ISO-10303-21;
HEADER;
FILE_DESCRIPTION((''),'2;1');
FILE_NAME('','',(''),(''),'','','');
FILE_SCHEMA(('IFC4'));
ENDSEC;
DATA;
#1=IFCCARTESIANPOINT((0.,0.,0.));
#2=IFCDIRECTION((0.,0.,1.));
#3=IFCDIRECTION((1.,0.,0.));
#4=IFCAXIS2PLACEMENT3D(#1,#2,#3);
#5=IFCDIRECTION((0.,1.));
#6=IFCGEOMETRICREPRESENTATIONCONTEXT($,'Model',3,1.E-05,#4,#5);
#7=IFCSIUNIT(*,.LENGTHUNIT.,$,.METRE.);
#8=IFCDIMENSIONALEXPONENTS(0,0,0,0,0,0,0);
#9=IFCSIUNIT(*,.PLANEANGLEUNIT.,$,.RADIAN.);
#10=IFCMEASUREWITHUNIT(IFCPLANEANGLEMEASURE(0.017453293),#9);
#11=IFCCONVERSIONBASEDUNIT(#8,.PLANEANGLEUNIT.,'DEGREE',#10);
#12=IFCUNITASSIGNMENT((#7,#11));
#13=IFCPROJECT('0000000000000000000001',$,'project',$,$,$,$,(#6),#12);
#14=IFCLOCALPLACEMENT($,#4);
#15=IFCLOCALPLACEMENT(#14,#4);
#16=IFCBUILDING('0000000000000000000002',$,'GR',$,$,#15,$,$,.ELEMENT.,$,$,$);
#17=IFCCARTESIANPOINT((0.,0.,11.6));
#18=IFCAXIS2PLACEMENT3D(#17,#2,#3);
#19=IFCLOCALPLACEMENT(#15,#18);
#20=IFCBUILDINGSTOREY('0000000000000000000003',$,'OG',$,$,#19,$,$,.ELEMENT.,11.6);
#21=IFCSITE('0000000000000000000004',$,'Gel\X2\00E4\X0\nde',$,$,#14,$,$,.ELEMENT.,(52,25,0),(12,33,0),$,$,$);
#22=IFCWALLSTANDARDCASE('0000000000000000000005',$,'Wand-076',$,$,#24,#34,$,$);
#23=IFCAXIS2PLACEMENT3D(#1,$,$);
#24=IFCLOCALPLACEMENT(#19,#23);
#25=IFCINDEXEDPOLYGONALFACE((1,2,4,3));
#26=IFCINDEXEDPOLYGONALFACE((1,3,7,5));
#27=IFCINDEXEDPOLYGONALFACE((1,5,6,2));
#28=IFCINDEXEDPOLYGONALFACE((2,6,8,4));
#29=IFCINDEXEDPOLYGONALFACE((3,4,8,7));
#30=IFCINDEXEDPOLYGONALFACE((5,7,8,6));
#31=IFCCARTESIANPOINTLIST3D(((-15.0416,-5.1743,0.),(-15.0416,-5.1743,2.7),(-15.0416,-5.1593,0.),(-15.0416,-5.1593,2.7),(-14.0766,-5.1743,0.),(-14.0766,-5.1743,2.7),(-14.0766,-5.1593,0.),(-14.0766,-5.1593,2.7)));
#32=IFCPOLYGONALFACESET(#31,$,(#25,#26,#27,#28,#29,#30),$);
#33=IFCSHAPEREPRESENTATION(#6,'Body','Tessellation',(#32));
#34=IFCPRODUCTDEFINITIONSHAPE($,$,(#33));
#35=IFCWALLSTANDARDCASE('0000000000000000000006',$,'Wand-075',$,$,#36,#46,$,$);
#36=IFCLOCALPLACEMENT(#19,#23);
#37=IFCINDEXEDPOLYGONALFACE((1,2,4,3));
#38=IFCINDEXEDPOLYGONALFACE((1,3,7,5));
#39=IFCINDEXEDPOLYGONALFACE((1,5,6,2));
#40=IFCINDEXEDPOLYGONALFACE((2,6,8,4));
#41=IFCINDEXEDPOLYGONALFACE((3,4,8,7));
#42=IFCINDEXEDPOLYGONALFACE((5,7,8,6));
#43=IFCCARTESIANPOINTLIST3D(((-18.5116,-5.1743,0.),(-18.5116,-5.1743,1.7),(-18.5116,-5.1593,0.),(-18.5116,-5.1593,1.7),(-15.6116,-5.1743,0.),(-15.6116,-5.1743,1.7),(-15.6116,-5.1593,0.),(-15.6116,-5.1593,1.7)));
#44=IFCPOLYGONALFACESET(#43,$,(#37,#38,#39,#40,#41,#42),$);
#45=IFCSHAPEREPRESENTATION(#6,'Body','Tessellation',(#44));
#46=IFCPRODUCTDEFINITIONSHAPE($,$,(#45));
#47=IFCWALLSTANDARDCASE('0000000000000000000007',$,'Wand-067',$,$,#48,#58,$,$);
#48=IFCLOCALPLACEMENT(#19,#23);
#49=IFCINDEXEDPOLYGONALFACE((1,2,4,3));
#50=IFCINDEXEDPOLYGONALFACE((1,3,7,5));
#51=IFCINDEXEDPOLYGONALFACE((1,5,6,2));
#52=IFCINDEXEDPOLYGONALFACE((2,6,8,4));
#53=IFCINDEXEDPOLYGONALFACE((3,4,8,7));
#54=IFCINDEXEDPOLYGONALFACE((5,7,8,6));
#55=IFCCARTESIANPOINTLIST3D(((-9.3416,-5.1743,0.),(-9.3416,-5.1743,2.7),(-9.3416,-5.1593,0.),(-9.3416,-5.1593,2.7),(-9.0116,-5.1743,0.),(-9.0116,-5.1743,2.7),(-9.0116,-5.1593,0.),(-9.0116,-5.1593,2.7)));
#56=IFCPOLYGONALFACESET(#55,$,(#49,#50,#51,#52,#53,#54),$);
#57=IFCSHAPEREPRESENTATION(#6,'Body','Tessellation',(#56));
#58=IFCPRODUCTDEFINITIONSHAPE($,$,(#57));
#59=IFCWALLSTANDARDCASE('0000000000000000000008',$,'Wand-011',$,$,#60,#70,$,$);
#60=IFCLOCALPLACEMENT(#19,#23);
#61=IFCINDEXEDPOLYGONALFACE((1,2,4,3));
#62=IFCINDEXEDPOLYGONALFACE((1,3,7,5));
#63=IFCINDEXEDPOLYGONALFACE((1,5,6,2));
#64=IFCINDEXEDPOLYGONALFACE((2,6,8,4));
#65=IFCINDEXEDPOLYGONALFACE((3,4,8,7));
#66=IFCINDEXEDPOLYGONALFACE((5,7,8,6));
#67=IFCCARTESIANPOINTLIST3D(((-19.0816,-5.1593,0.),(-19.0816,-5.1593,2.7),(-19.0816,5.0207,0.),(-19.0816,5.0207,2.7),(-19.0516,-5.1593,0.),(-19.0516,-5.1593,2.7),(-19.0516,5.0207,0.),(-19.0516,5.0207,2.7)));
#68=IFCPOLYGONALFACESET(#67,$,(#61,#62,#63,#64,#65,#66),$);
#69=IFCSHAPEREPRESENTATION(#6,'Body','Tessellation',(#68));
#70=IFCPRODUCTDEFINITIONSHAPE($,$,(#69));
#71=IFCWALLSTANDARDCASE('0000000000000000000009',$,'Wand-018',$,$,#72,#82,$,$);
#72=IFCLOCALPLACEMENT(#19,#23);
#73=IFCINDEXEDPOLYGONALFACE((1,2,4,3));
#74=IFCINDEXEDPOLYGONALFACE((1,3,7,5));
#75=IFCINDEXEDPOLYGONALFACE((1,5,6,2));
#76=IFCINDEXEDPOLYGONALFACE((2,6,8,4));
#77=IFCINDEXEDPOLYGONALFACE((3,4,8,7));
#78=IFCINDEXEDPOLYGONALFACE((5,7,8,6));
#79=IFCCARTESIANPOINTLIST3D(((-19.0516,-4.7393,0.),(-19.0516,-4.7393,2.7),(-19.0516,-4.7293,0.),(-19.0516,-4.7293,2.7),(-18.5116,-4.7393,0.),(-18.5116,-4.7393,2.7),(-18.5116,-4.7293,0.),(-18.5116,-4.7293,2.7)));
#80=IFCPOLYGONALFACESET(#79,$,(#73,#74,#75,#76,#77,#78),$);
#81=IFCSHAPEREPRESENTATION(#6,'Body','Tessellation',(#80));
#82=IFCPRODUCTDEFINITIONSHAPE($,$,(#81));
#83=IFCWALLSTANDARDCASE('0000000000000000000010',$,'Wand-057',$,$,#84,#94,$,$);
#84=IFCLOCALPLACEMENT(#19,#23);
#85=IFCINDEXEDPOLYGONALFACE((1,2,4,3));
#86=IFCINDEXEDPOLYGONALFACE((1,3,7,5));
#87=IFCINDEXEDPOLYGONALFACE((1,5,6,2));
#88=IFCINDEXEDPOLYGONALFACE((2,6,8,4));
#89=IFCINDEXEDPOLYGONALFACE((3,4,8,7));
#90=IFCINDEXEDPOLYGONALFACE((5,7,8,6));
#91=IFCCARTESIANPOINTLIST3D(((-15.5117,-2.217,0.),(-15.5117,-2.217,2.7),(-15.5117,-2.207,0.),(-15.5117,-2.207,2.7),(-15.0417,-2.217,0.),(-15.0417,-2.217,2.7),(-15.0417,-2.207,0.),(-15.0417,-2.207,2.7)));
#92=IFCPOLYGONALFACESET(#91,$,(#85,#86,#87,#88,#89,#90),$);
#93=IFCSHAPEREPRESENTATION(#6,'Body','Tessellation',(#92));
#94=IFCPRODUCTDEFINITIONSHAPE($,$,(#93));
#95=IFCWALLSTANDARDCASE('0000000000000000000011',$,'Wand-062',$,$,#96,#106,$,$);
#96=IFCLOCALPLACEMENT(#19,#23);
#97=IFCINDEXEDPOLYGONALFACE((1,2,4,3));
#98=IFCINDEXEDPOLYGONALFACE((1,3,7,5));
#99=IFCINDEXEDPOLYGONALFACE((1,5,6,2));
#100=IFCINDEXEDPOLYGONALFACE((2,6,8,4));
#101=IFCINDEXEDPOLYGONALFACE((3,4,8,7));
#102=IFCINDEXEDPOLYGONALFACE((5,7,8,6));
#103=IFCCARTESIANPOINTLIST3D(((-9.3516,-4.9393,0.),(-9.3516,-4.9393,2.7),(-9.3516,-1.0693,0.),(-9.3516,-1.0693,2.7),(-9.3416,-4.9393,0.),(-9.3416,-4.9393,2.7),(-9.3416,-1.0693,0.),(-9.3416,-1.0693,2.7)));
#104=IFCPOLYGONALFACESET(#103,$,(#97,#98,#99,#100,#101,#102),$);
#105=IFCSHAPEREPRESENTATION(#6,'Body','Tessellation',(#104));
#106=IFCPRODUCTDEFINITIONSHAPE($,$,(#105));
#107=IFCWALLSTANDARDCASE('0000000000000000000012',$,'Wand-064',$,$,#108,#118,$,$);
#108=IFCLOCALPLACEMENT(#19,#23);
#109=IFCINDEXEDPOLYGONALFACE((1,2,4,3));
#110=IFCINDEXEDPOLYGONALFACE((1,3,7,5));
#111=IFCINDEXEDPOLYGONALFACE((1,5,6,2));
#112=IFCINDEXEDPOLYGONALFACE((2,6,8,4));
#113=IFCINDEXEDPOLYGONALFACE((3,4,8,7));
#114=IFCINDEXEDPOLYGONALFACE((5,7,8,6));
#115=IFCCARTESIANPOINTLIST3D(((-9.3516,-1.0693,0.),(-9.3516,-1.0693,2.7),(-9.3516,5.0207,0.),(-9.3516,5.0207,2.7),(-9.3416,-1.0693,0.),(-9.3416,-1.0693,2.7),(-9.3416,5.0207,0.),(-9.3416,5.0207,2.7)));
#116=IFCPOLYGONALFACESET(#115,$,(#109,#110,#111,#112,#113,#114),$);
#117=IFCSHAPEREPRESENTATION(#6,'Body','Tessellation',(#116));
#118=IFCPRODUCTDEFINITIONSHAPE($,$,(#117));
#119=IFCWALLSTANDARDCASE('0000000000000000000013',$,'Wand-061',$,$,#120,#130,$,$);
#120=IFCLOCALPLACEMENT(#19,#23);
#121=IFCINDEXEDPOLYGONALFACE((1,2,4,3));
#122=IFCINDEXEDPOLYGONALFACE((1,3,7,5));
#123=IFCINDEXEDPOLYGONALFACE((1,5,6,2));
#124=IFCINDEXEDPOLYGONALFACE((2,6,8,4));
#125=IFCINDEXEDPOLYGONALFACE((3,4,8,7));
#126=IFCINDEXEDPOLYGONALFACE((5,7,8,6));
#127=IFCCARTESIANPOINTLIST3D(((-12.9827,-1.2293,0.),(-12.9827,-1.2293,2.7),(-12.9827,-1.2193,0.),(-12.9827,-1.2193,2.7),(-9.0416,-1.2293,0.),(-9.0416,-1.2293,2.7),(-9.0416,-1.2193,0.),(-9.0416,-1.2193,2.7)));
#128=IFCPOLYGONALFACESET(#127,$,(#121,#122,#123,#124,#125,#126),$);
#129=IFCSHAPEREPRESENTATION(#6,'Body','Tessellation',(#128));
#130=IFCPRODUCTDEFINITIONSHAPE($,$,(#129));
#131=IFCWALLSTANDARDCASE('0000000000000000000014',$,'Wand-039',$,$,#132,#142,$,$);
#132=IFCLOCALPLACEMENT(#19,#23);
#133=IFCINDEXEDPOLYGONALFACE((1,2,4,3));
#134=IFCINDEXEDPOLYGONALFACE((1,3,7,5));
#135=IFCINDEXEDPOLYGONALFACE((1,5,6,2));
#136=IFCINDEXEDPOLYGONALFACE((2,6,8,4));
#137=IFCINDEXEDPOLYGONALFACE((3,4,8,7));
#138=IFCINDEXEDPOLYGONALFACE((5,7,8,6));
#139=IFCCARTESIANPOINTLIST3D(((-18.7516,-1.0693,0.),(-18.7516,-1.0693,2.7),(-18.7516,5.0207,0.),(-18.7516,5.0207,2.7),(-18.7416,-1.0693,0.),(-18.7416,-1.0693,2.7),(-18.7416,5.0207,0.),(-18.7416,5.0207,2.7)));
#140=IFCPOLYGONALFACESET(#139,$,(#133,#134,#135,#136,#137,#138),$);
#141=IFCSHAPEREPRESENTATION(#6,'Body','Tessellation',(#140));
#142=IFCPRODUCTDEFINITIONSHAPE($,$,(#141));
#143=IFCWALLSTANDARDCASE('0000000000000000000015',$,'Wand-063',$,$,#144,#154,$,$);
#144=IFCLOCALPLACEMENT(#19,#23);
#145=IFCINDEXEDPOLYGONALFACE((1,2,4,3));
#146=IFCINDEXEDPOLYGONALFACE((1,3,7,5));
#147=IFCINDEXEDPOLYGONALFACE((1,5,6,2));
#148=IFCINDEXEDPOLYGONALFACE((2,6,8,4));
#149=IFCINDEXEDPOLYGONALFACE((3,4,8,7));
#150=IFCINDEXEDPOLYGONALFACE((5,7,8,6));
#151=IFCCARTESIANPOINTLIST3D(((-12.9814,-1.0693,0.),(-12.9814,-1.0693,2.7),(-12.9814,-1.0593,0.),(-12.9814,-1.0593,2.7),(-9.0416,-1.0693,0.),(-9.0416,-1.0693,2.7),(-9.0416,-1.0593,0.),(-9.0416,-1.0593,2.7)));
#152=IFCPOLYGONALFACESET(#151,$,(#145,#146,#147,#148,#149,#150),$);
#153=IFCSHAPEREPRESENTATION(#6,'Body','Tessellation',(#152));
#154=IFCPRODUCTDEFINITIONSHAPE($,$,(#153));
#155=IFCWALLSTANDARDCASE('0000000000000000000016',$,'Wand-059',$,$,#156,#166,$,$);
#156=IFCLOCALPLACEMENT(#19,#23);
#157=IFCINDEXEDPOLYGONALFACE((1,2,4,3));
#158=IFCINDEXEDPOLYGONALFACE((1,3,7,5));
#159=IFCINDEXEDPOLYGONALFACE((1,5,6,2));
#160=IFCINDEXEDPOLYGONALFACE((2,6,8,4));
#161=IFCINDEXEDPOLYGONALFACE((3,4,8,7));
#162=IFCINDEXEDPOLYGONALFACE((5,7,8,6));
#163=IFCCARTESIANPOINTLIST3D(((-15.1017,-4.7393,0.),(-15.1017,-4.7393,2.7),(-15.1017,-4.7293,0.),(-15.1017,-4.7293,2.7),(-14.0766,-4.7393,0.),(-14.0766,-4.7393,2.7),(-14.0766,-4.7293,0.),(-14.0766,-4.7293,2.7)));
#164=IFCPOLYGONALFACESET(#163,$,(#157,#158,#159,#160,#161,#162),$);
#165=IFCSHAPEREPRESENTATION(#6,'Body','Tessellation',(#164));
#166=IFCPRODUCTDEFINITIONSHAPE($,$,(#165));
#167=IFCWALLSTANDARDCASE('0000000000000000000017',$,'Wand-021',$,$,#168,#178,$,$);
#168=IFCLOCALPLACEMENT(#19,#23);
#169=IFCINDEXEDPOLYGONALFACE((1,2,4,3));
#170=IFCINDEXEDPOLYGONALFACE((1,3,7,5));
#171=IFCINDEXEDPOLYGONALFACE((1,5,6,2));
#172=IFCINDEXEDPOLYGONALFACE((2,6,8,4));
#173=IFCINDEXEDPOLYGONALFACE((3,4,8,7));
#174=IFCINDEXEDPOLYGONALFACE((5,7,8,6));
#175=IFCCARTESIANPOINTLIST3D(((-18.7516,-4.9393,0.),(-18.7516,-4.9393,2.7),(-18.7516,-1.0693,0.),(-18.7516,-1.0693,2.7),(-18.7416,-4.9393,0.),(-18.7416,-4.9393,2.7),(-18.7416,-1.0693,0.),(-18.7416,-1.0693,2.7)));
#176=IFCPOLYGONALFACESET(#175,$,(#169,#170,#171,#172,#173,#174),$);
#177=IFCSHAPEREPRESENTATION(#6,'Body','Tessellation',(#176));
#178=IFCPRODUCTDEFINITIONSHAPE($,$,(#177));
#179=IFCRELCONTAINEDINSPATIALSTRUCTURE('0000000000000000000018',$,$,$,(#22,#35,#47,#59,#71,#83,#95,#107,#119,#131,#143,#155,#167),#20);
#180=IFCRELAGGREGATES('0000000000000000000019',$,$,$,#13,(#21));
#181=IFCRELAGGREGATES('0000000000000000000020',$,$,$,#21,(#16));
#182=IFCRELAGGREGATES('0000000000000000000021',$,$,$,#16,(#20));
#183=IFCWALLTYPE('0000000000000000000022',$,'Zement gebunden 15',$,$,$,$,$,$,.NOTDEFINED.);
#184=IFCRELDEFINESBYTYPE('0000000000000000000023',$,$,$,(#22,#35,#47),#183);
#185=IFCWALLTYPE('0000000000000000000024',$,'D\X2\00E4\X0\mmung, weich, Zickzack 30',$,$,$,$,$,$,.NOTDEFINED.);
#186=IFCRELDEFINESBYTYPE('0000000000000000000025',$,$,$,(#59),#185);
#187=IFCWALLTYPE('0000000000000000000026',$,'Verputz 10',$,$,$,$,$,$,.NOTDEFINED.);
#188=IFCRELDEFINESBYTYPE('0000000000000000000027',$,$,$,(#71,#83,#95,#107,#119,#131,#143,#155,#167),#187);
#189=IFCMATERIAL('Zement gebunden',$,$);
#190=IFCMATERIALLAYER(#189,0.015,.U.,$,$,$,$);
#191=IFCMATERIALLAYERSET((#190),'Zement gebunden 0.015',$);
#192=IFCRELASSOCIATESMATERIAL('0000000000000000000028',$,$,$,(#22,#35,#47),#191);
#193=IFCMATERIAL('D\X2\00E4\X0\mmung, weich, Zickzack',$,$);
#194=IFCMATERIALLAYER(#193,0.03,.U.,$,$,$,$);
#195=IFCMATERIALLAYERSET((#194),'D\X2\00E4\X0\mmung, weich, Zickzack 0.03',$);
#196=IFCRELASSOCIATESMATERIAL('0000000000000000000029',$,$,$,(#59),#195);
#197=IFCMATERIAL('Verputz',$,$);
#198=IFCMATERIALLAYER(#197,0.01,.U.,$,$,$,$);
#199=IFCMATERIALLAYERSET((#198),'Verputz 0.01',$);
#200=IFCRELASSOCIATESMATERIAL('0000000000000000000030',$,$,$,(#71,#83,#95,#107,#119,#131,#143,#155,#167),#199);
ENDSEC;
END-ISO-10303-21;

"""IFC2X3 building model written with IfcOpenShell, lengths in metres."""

from ifc_helpers import new_model, entity, si_unit, converted_unit, direction, frame, origin_with_axes, place, context, project, spatial, polyline, outline, extrude, material, layer, layer_set, layer_usage, type_object, element, save


model = new_model("IFC2X3")

# Units and contexts
model_context = context("Model", 3, precision=1e-05, world=origin_with_axes(), true_north=direction((0.0, 1.0)))
ifc_project = project(units=[si_unit("LENGTHUNIT", "METRE"), converted_unit("PLANEANGLEUNIT", "DEGREE", entity("IfcPlaneAngleMeasure", 0.017453293), si_unit("PLANEANGLEUNIT", "RADIAN"), dimensions=[0, 0, 0, 0, 0, 0, 0])], contexts=[model_context])

# Site, building, storey
site_placement = place(None, origin_with_axes())
site = spatial("IfcSite", under=ifc_project, at=site_placement, Name="Gelände", CompositionType="ELEMENT", RefLatitude=(52, 25, 0), RefLongitude=(12, 33, 0))
building_placement = place(site_placement, origin_with_axes())
building = spatial("IfcBuilding", under=site, at=building_placement, Name="GR", CompositionType="ELEMENT")
storey_placement = place(building_placement, frame((0.0, 0.0, 11.6), z_axis=(0.0, 0.0, 1.0), x_axis=(1.0, 0.0, 0.0)))
storey = spatial("IfcBuildingStorey", under=building, at=storey_placement, Name="OG", CompositionType="ELEMENT", Elevation=11.6)

# Walls
ifc_material_1 = material(Name="Zement gebunden")
ifc_layer_1 = layer(ifc_material_1, 0.015, ventilated="UNKNOWN")
ifc_layer_set_1 = layer_set([ifc_layer_1], Name="Zement gebunden 0.015")
ifc_layer_usage_1 = layer_usage(ifc_layer_set_1, "AXIS2", "NEGATIVE", 0.0)
wall_type_1 = type_object("IfcWallType", Name="Zement gebunden 15", PredefinedType="NOTDEFINED")
wall_1_placement = place(storey_placement, frame((-15.0416, -5.1593, 0.0), z_axis=(0.0, 0.0, 1.0), x_axis=(1.0, 0.0, 0.0)))
element("IfcWallStandardCase", 1, at=wall_1_placement, inside=storey, type_object=wall_type_1, material=ifc_layer_usage_1, Name="Wand-076", context=model_context, shape_type="SweptSolid", body=[
    extrude(outline(polyline([(0.0, -0.015), (0.965, -0.015), (0.965, 0.0), (0.0, 0.0), (0.0, -0.015)])), origin_with_axes(), (0.0, 0.0, 1.0), 2.7),
])
ifc_layer_usage_2 = layer_usage(ifc_layer_set_1, "AXIS2", "NEGATIVE", 0.0)
wall_2_placement = place(storey_placement, frame((-18.5116, -5.1593, 0.0), z_axis=(0.0, 0.0, 1.0), x_axis=(1.0, 0.0, 0.0)))
element("IfcWallStandardCase", 2, at=wall_2_placement, inside=storey, type_object=wall_type_1, material=ifc_layer_usage_2, Name="Wand-075", context=model_context, shape_type="SweptSolid", body=[
    extrude(outline(polyline([(0.0, -0.015), (2.9, -0.015), (2.9, 0.0), (0.0, 0.0), (0.0, -0.015)])), origin_with_axes(), (0.0, 0.0, 1.0), 1.7),
])
ifc_layer_usage_3 = layer_usage(ifc_layer_set_1, "AXIS2", "NEGATIVE", 0.0)
wall_3_placement = place(storey_placement, frame((-9.3416, -5.1593, 0.0), z_axis=(0.0, 0.0, 1.0), x_axis=(1.0, 0.0, 0.0)))
element("IfcWallStandardCase", 3, at=wall_3_placement, inside=storey, type_object=wall_type_1, material=ifc_layer_usage_3, Name="Wand-067", context=model_context, shape_type="SweptSolid", body=[
    extrude(outline(polyline([(0.0, -0.015), (0.33, -0.015), (0.33, 0.0), (0.0, 0.0), (0.0, -0.015)])), origin_with_axes(), (0.0, 0.0, 1.0), 2.7),
])
ifc_material_2 = material(Name="Dämmung, weich, Zickzack")
ifc_layer_2 = layer(ifc_material_2, 0.03, ventilated="UNKNOWN")
ifc_layer_set_2 = layer_set([ifc_layer_2], Name="Dämmung, weich, Zickzack 0.03")
ifc_layer_usage_4 = layer_usage(ifc_layer_set_2, "AXIS2", "POSITIVE", 0.0)
wall_type_2 = type_object("IfcWallType", Name="Dämmung, weich, Zickzack 30", PredefinedType="NOTDEFINED")
wall_4_placement = place(storey_placement, frame((-19.0516, -5.1593, 0.0), z_axis=(0.0, 0.0, 1.0), x_axis=(0.0, 1.0, 0.0)))
element("IfcWallStandardCase", 4, at=wall_4_placement, inside=storey, type_object=wall_type_2, material=ifc_layer_usage_4, Name="Wand-011", context=model_context, shape_type="SweptSolid", body=[
    extrude(outline(polyline([(0.0, 0.0), (10.18, 0.0), (10.18, 0.03), (0.0, 0.03), (0.0, 0.0)])), origin_with_axes(), (0.0, 0.0, 1.0), 2.7),
])

# Walls
ifc_material_3 = material(Name="Verputz")
ifc_layer_3 = layer(ifc_material_3, 0.01, ventilated="UNKNOWN")
ifc_layer_set_3 = layer_set([ifc_layer_3], Name="Verputz 0.01")
ifc_layer_usage_5 = layer_usage(ifc_layer_set_3, "AXIS2", "POSITIVE", 0.0)
wall_type_3 = type_object("IfcWallType", Name="Verputz 10", PredefinedType="NOTDEFINED")
wall_5_placement = place(storey_placement, frame((-19.0516, -4.7393, 0.0), z_axis=(0.0, 0.0, 1.0), x_axis=(1.0, 0.0, 0.0)))
element("IfcWallStandardCase", 5, at=wall_5_placement, inside=storey, type_object=wall_type_3, material=ifc_layer_usage_5, Name="Wand-018", context=model_context, shape_type="SweptSolid", body=[
    extrude(outline(polyline([(0.0, 0.0), (0.54, 0.0), (0.54, 0.01), (0.0, 0.01), (0.0, 0.0)])), origin_with_axes(), (0.0, 0.0, 1.0), 2.7),
])
ifc_layer_usage_6 = layer_usage(ifc_layer_set_3, "AXIS2", "POSITIVE", 0.0)
wall_6_placement = place(storey_placement, frame((-15.5117, -2.217, 0.0), z_axis=(0.0, 0.0, 1.0), x_axis=(1.0, 0.0, 0.0)))
element("IfcWallStandardCase", 6, at=wall_6_placement, inside=storey, type_object=wall_type_3, material=ifc_layer_usage_6, Name="Wand-057", context=model_context, shape_type="SweptSolid", body=[
    extrude(outline(polyline([(0.0, 0.0), (0.47, 0.0), (0.47, 0.01), (0.0, 0.01), (0.0, 0.0)])), origin_with_axes(), (0.0, 0.0, 1.0), 2.7),
])
ifc_layer_usage_7 = layer_usage(ifc_layer_set_3, "AXIS2", "NEGATIVE", 0.0)
wall_7_placement = place(storey_placement, frame((-9.3416, -1.0693, 0.0), z_axis=(0.0, 0.0, 1.0), x_axis=(0.0, -1.0, 0.0)))
element("IfcWallStandardCase", 7, at=wall_7_placement, inside=storey, type_object=wall_type_3, material=ifc_layer_usage_7, Name="Wand-062", context=model_context, shape_type="SweptSolid", body=[
    extrude(outline(polyline([(0.0, -0.01), (3.87, -0.01), (3.87, 0.0), (0.0, 0.0), (0.0, -0.01)])), origin_with_axes(), (0.0, 0.0, 1.0), 2.7),
])
ifc_layer_usage_8 = layer_usage(ifc_layer_set_3, "AXIS2", "POSITIVE", 0.0)
wall_8_placement = place(storey_placement, frame((-9.3416, -1.0693, 0.0), z_axis=(0.0, 0.0, 1.0), x_axis=(0.0, 1.0, 0.0)))
element("IfcWallStandardCase", 8, at=wall_8_placement, inside=storey, type_object=wall_type_3, material=ifc_layer_usage_8, Name="Wand-064", context=model_context, shape_type="SweptSolid", body=[
    extrude(outline(polyline([(0.0, 0.0), (6.09, 0.0), (6.09, 0.01), (0.0, 0.01), (0.0, 0.0)])), origin_with_axes(), (0.0, 0.0, 1.0), 2.7),
])
ifc_layer_usage_9 = layer_usage(ifc_layer_set_3, "AXIS2", "NEGATIVE", 0.0)
wall_9_placement = place(storey_placement, frame((-12.9827, -1.2193, 0.0), z_axis=(0.0, 0.0, 1.0), x_axis=(1.0, 0.0, 0.0)))
element("IfcWallStandardCase", 9, at=wall_9_placement, inside=storey, type_object=wall_type_3, material=ifc_layer_usage_9, Name="Wand-061", context=model_context, shape_type="SweptSolid", body=[
    extrude(outline(polyline([(0.0, -0.01), (3.9411, -0.01), (3.9411, 0.0), (0.0, 0.0), (0.0, -0.01)])), origin_with_axes(), (0.0, 0.0, 1.0), 2.7),
])
ifc_layer_usage_10 = layer_usage(ifc_layer_set_3, "AXIS2", "NEGATIVE", 0.0)
wall_10_placement = place(storey_placement, frame((-18.7516, -1.0693, 0.0), z_axis=(0.0, 0.0, 1.0), x_axis=(0.0, 1.0, 0.0)))
element("IfcWallStandardCase", 10, at=wall_10_placement, inside=storey, type_object=wall_type_3, material=ifc_layer_usage_10, Name="Wand-039", context=model_context, shape_type="SweptSolid", body=[
    extrude(outline(polyline([(0.0, -0.01), (6.09, -0.01), (6.09, 0.0), (0.0, 0.0), (0.0, -0.01)])), origin_with_axes(), (0.0, 0.0, 1.0), 2.7),
])
ifc_layer_usage_11 = layer_usage(ifc_layer_set_3, "AXIS2", "POSITIVE", 0.0)
wall_11_placement = place(storey_placement, frame((-12.9814, -1.0693, 0.0), z_axis=(0.0, 0.0, 1.0), x_axis=(1.0, 0.0, 0.0)))
element("IfcWallStandardCase", 11, at=wall_11_placement, inside=storey, type_object=wall_type_3, material=ifc_layer_usage_11, Name="Wand-063", context=model_context, shape_type="SweptSolid", body=[
    extrude(outline(polyline([(0.0, 0.0), (3.9398, 0.0), (3.9398, 0.01), (0.0, 0.01), (0.0, 0.0)])), origin_with_axes(), (0.0, 0.0, 1.0), 2.7),
])
ifc_layer_usage_12 = layer_usage(ifc_layer_set_3, "AXIS2", "POSITIVE", 0.0)
wall_12_placement = place(storey_placement, frame((-15.1017, -4.7393, 0.0), z_axis=(0.0, 0.0, 1.0), x_axis=(1.0, 0.0, 0.0)))
element("IfcWallStandardCase", 12, at=wall_12_placement, inside=storey, type_object=wall_type_3, material=ifc_layer_usage_12, Name="Wand-059", context=model_context, shape_type="SweptSolid", body=[
    extrude(outline(polyline([(0.0, 0.0), (1.025, 0.0), (1.025, 0.01), (0.0, 0.01), (0.0, 0.0)])), origin_with_axes(), (0.0, 0.0, 1.0), 2.7),
])
ifc_layer_usage_13 = layer_usage(ifc_layer_set_3, "AXIS2", "POSITIVE", 0.0)
wall_13_placement = place(storey_placement, frame((-18.7516, -1.0693, 0.0), z_axis=(0.0, 0.0, 1.0), x_axis=(0.0, -1.0, 0.0)))
element("IfcWallStandardCase", 13, at=wall_13_placement, inside=storey, type_object=wall_type_3, material=ifc_layer_usage_13, Name="Wand-021", context=model_context, shape_type="SweptSolid", body=[
    extrude(outline(polyline([(0.0, 0.0), (3.87, 0.0), (3.87, 0.01), (0.0, 0.01), (0.0, 0.0)])), origin_with_axes(), (0.0, 0.0, 1.0), 2.7),
])

save(model, "model.ifc")
